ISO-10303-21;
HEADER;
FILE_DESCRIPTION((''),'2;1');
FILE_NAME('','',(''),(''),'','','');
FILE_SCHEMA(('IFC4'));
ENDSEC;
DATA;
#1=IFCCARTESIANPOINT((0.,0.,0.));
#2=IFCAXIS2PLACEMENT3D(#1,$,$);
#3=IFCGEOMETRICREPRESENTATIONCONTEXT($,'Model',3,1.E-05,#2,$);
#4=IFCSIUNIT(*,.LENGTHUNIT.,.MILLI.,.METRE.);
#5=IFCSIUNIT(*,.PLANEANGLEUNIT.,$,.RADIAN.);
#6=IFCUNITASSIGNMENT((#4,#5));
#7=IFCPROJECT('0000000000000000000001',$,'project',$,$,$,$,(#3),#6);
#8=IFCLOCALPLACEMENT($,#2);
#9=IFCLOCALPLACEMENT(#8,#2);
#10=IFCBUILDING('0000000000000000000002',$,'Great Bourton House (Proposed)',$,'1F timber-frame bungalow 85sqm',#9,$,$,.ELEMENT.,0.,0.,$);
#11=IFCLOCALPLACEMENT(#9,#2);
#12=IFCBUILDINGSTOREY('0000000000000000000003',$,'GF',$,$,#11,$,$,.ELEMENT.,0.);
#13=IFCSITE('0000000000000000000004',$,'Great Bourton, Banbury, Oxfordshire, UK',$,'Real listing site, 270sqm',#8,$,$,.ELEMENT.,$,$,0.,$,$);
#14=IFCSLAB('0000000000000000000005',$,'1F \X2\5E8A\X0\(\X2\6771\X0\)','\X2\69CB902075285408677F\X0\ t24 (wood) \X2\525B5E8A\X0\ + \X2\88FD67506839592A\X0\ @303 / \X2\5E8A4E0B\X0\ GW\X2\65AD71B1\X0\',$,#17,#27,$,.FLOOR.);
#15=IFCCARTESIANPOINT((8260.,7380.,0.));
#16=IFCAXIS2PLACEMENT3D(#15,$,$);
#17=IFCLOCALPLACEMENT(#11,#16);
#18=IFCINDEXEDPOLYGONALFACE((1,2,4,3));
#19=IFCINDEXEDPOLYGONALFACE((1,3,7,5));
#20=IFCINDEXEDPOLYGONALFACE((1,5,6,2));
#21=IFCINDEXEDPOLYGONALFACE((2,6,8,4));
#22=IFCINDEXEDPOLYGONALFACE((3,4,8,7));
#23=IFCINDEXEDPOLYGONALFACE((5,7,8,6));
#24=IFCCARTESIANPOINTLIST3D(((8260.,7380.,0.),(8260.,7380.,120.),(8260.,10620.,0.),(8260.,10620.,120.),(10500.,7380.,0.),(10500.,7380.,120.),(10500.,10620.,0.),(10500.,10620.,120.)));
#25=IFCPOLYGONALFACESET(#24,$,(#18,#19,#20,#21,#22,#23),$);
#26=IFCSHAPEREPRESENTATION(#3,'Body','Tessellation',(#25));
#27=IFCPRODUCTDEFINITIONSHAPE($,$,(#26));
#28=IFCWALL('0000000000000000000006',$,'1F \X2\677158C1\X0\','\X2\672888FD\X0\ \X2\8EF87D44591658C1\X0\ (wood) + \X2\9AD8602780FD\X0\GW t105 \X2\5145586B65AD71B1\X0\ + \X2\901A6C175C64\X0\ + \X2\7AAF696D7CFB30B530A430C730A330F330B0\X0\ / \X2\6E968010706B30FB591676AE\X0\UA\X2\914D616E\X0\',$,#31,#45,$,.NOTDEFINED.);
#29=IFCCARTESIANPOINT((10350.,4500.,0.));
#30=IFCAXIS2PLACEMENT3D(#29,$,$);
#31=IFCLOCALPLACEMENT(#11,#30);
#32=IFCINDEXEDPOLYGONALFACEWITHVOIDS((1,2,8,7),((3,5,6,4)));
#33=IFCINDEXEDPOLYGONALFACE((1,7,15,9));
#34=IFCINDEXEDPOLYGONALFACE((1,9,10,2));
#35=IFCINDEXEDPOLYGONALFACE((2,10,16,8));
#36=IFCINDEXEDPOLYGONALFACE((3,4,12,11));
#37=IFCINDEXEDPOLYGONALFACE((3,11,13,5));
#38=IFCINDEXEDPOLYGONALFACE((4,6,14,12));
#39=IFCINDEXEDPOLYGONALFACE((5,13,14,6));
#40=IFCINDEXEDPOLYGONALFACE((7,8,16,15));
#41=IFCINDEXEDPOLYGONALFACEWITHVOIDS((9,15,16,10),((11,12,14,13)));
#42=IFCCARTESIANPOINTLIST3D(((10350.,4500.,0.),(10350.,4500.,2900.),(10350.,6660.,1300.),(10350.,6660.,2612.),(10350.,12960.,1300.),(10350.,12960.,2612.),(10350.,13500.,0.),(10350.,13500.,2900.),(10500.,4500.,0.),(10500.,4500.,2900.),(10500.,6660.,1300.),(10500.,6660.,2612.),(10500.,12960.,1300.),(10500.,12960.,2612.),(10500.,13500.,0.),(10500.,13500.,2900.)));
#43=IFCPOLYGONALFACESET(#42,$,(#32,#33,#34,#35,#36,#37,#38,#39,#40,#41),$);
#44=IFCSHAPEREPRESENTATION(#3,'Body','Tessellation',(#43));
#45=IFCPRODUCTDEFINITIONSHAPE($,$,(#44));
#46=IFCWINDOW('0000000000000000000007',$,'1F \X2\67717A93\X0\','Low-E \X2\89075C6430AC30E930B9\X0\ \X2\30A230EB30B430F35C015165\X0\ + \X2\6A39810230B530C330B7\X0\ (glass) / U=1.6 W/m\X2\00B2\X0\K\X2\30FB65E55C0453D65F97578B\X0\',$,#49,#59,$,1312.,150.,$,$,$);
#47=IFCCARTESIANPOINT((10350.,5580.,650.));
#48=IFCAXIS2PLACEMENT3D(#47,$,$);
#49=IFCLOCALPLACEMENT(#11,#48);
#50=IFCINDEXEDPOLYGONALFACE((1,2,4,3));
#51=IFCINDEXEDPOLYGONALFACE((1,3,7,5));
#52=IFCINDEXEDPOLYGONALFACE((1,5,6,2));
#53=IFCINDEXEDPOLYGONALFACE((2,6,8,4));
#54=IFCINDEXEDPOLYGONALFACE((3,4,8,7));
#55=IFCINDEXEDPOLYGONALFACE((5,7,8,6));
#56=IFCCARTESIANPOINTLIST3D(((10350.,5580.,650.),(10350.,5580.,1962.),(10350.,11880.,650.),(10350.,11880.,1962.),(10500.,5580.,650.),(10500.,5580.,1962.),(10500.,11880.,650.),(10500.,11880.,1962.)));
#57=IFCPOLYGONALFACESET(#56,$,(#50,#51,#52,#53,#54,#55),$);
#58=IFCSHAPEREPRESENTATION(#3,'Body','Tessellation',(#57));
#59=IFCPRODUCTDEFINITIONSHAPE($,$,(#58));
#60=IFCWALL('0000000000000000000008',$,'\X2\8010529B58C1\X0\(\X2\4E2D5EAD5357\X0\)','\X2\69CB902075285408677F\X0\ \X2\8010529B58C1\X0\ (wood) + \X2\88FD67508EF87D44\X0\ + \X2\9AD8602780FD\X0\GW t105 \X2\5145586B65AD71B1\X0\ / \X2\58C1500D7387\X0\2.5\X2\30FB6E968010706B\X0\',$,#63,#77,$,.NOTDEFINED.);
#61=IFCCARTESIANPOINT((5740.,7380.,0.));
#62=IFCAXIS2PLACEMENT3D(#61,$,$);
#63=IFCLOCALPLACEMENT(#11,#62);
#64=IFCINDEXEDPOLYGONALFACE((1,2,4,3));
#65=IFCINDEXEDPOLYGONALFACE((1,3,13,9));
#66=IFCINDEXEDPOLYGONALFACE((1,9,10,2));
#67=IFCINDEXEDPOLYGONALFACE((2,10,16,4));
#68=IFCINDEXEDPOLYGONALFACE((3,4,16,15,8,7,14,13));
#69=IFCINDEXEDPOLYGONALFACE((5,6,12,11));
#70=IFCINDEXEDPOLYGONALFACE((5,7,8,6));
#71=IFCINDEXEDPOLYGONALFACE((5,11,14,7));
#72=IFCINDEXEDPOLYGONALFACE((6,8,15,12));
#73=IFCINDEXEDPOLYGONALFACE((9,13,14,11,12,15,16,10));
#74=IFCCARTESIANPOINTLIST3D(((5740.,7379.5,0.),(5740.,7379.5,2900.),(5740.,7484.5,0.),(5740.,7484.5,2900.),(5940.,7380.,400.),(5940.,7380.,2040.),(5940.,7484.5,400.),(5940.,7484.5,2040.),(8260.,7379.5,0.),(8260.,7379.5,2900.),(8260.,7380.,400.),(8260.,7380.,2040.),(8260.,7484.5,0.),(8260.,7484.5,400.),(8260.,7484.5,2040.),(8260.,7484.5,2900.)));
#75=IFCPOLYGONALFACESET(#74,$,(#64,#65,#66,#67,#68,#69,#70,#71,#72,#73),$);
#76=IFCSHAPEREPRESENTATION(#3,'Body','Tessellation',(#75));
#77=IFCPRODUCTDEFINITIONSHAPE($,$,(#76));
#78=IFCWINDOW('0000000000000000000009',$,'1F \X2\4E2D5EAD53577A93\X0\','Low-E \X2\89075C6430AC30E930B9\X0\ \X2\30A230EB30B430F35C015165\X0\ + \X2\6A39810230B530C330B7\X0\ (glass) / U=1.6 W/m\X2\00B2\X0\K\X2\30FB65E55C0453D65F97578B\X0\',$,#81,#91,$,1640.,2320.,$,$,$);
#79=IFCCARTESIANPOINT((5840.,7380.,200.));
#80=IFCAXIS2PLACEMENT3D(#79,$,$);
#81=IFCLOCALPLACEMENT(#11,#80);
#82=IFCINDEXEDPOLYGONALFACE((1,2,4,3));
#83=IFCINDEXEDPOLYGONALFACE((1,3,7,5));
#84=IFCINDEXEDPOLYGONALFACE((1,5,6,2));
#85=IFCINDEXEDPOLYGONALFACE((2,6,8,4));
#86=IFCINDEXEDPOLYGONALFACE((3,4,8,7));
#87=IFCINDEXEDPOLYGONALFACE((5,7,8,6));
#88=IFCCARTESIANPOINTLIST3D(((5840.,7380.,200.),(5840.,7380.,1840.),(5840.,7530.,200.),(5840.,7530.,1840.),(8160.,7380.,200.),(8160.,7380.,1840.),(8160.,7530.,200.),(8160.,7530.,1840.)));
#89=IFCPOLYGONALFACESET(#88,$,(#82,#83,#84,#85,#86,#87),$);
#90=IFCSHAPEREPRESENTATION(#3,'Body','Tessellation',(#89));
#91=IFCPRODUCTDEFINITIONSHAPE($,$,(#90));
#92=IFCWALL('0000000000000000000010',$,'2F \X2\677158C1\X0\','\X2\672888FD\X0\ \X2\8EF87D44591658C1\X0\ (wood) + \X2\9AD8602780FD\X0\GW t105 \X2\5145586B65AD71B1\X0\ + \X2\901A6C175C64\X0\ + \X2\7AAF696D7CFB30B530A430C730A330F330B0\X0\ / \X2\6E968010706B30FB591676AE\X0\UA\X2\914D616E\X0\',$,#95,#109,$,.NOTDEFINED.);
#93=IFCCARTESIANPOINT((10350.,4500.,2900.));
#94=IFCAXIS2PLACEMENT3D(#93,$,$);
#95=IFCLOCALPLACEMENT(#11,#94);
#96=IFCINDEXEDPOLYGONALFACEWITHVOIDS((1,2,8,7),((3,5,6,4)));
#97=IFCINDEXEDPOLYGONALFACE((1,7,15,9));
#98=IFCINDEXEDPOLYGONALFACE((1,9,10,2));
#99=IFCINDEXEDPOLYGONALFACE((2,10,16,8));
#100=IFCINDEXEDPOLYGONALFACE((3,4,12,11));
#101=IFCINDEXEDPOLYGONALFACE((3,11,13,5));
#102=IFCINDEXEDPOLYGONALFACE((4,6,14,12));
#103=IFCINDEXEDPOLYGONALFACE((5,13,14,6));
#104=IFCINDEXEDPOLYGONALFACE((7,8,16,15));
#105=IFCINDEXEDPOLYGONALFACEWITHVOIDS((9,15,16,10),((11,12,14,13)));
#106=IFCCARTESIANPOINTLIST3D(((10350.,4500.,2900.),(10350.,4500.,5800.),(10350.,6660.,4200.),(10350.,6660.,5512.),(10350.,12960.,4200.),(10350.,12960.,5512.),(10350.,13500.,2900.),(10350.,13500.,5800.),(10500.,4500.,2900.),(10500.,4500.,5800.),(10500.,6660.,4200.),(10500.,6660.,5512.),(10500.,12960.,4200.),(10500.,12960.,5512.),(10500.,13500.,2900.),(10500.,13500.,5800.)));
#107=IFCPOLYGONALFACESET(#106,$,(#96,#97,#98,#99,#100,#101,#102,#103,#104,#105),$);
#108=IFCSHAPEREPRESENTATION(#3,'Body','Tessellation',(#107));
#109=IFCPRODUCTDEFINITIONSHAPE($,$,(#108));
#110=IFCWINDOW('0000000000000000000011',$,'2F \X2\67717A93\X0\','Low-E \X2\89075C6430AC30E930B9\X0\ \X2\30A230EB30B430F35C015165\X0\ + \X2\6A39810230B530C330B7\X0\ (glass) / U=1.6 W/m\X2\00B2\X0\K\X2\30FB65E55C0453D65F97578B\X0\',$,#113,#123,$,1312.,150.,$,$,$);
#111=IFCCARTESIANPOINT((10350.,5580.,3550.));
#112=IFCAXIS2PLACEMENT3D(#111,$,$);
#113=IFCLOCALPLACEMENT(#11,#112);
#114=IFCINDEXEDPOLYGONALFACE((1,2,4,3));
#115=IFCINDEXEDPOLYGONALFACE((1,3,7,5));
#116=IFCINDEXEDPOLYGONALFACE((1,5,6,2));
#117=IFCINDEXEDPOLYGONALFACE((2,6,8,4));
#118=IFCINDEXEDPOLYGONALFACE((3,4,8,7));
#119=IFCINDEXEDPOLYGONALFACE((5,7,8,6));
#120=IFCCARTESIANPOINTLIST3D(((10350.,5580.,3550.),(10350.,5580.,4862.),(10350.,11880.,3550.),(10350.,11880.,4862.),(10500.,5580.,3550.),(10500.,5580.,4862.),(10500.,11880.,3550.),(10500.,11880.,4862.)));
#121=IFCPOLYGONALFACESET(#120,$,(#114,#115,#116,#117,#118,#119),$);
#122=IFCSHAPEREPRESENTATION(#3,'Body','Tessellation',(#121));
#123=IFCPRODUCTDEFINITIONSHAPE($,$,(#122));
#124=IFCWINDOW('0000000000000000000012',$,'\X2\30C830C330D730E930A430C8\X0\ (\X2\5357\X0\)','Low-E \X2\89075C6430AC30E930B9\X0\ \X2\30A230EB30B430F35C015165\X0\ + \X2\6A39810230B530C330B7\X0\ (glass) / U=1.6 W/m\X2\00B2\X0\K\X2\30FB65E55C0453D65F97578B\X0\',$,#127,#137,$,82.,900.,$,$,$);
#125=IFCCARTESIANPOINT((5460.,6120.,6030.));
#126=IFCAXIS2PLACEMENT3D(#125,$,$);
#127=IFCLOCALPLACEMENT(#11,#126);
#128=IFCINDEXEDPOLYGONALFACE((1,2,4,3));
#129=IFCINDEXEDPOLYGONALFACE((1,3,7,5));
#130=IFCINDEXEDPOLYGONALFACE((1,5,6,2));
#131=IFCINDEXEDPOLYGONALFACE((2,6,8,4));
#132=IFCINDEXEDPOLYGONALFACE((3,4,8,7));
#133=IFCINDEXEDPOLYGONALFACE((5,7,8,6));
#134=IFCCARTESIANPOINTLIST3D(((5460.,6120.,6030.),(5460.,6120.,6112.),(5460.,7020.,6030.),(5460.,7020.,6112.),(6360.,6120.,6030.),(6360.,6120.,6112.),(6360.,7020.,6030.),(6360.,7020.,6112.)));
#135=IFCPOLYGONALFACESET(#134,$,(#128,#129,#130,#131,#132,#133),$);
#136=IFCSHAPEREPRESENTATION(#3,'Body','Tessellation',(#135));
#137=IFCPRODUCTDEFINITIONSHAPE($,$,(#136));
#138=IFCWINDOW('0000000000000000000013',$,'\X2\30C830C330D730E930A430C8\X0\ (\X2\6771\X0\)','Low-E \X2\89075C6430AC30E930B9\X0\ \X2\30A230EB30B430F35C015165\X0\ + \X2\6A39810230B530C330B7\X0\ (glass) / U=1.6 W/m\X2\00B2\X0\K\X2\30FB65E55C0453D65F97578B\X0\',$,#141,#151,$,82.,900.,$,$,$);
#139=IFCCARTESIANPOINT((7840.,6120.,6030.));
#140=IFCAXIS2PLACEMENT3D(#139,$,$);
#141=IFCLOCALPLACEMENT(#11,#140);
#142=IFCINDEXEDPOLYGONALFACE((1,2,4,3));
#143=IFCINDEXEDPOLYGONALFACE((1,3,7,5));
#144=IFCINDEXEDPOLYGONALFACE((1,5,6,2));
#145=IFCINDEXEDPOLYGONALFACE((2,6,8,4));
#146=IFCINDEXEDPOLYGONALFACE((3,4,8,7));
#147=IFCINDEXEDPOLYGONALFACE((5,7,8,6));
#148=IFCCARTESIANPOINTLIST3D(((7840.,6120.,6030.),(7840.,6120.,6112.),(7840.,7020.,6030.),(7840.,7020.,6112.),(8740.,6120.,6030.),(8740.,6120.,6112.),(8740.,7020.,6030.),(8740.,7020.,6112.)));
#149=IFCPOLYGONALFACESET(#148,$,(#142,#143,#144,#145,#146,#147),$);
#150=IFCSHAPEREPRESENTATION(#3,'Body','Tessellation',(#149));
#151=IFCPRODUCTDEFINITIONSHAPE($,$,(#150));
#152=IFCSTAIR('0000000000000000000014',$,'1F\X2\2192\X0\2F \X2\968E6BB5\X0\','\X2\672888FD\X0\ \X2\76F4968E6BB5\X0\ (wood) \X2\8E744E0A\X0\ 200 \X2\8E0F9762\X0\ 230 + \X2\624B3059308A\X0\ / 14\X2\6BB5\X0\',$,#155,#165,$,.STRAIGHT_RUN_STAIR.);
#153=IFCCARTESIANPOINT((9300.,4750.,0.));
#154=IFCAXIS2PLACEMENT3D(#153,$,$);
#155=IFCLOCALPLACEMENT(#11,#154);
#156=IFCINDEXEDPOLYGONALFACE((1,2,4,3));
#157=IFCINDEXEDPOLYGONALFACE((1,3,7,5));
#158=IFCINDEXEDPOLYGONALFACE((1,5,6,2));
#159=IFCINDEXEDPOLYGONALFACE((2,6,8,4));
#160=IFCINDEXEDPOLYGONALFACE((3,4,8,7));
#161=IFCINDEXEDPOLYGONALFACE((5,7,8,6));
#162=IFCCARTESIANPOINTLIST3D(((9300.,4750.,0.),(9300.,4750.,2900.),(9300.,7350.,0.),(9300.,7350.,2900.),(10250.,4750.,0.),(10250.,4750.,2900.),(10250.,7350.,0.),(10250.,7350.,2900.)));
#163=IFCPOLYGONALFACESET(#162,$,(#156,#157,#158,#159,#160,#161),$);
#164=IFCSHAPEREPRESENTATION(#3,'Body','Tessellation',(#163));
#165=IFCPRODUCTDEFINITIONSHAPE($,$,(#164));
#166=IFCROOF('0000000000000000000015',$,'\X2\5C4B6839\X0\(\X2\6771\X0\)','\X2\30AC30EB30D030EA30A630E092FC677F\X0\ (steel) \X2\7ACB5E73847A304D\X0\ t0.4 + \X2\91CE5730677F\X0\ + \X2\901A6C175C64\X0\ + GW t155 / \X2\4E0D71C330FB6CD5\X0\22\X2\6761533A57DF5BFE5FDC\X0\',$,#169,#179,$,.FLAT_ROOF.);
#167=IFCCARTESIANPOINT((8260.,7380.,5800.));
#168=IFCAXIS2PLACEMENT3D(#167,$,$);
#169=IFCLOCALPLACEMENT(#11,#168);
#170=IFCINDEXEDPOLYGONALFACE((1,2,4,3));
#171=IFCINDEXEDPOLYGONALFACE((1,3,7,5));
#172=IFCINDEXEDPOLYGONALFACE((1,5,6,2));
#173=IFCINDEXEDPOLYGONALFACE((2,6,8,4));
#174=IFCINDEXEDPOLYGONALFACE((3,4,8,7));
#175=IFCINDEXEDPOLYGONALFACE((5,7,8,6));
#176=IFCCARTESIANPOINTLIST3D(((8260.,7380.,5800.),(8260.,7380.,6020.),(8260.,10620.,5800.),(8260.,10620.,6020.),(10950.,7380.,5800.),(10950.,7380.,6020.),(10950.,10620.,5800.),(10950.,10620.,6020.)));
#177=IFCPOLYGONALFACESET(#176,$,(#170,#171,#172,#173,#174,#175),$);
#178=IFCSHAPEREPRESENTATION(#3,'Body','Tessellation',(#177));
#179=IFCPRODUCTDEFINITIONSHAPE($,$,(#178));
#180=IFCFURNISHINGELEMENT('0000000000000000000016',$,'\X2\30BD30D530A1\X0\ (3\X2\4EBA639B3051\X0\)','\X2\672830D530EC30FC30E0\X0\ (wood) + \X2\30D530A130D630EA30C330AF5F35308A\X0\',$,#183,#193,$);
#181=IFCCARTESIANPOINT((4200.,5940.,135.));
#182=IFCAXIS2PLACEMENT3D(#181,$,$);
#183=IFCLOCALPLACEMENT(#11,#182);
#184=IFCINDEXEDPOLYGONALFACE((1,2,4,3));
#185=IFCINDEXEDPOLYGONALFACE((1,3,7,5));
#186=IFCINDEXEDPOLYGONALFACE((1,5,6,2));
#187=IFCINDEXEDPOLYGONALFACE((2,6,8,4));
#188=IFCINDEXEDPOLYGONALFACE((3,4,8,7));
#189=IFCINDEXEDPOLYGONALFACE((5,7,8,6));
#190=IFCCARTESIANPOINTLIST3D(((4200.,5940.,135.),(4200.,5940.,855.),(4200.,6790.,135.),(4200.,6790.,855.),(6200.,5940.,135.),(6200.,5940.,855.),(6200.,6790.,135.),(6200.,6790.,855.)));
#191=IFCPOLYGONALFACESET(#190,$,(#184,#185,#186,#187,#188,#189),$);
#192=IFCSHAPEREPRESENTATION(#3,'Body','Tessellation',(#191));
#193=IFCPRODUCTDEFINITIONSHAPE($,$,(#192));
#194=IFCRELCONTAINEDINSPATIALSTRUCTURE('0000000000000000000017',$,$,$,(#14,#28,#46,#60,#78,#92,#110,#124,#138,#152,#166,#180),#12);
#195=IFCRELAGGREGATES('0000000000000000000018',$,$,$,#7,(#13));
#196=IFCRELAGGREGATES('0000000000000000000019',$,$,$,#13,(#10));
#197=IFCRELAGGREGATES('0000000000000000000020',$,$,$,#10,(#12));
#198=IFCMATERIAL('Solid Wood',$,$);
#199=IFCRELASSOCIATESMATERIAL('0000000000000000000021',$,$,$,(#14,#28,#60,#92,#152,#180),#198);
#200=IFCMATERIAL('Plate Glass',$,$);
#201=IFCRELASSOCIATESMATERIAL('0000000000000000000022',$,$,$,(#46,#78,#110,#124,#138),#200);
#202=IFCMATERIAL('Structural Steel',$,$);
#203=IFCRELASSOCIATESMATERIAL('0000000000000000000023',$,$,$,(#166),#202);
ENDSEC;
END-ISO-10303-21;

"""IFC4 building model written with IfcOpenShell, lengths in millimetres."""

from ifc_helpers import new_model, si_unit, frame, frame_2d, origin, place, context, project, spatial, rectangle, extrude, material, element, fill, save


model = new_model("IFC4")

# Units and contexts
model_context = context("Model", 3, precision=1e-05, world=origin())
ifc_project = project(units=[si_unit("LENGTHUNIT", "METRE", prefix="MILLI"), si_unit("PLANEANGLEUNIT", "RADIAN")], contexts=[model_context])

# Site, building, storey
site_placement = place(None, origin())
site = spatial("IfcSite", under=ifc_project, at=site_placement, Name="Great Bourton, Banbury, Oxfordshire, UK", ObjectType="Real listing site, 270sqm", CompositionType="ELEMENT", RefElevation=0.0)
building_placement = place(site_placement, origin())
building = spatial("IfcBuilding", under=site, at=building_placement, Name="Great Bourton House (Proposed)", ObjectType="1F timber-frame bungalow 85sqm", CompositionType="ELEMENT", ElevationOfRefHeight=0.0, ElevationOfTerrain=0.0)
storey_placement = place(building_placement, origin())
storey = spatial("IfcBuildingStorey", under=building, at=storey_placement, Name="GF", CompositionType="ELEMENT", Elevation=0.0)

# Slab
ifc_material_1 = material(Name="Solid Wood")
slab_placement = place(storey_placement, frame((8260.0, 7380.0, 0.0)))
element("IfcSlab", 1, at=slab_placement, inside=storey, material=ifc_material_1, Name="1F 床(東)", Description="構造用合板 t24 (wood) 剛床 + 製材根太 @303 / 床下 GW断熱", PredefinedType="FLOOR", context=model_context, shape_type="SweptSolid", body=[
    extrude(rectangle(XDim=2240.0, YDim=3240.0, at=frame_2d((1120.0, 1620.0))), frame((8260.0, 7380.0, 0.0)), (0.0, 0.0, 1.0), 120.0),
])

# Walls, openings, windows
wall_1_placement = place(storey_placement, frame((10350.0, 4500.0, 0.0)))
wall_1 = element("IfcWall", 2, at=wall_1_placement, inside=storey, material=ifc_material_1, Name="1F 東壁", Description="木製 軸組外壁 (wood) + 高性能GW t105 充填断熱 + 通気層 + 窯業系サイディング / 準耐火・外皮UA配慮", PredefinedType="NOTDEFINED", context=model_context, shape_type="SweptSolid", body=[
    extrude(rectangle(XDim=150.0, YDim=9000.0, at=frame_2d((75.0, 4500.0))), frame((10350.0, 4500.0, 0.0)), (0.0, 0.0, 1.0), 2900.0),
])
opening_1_placement = place(storey_placement, frame((10350.0, 5580.0, 650.0)))
opening_1 = element("IfcOpeningElement", 3, at=opening_1_placement, cuts=wall_1, PredefinedType="NOTDEFINED", context=model_context, shape_type="SweptSolid", body=[
    extrude(rectangle(XDim=150.0, YDim=6300.0, at=frame_2d((75.0, 3150.0))), frame((10350.0, 5580.0, 650.0)), (0.0, 0.0, 1.0), 1312.0),
])
ifc_material_2 = material(Name="Plate Glass")
window_1_placement = place(storey_placement, frame((10350.0, 5580.0, 650.0)))
window_1 = element("IfcWindow", 4, at=window_1_placement, inside=storey, material=ifc_material_2, Name="1F 東窓", Description="Low-E 複層ガラス アルゴン封入 + 樹脂サッシ (glass) / U=1.6 W/m²K・日射取得型", OverallHeight=1312.0, OverallWidth=150.0, context=model_context, shape_type="SweptSolid", body=[
    extrude(rectangle(XDim=150.0, YDim=6300.0, at=frame_2d((75.0, 3150.0))), frame((10350.0, 5580.0, 650.0)), (0.0, 0.0, 1.0), 1312.0),
])
fill(opening_1, window_1)
wall_2_placement = place(storey_placement, frame((5740.0, 7380.0, 0.0)))
wall_2 = element("IfcWall", 5, at=wall_2_placement, inside=storey, material=ifc_material_1, Name="耐力壁(中庭南)", Description="構造用合板 耐力壁 (wood) + 製材軸組 + 高性能GW t105 充填断熱 / 壁倍率2.5・準耐火", PredefinedType="NOTDEFINED", context=model_context, shape_type="SweptSolid", body=[
    extrude(rectangle(XDim=2520.0, YDim=105.0, at=frame_2d((1260.0, 52.0))), frame((5740.0, 7380.0, 0.0)), (0.0, 0.0, 1.0), 2900.0),
])
opening_2_placement = place(storey_placement, frame((5840.0, 7380.0, 200.0)))
opening_2 = element("IfcOpeningElement", 6, at=opening_2_placement, cuts=wall_2, PredefinedType="NOTDEFINED", context=model_context, shape_type="SweptSolid", body=[
    extrude(rectangle(XDim=2320.0, YDim=150.0, at=frame_2d((1160.0, 75.0))), frame((5840.0, 7380.0, 200.0)), (0.0, 0.0, 1.0), 1640.0),
])
window_2_placement = place(storey_placement, frame((5840.0, 7380.0, 200.0)))
window_2 = element("IfcWindow", 7, at=window_2_placement, inside=storey, material=ifc_material_2, Name="1F 中庭南窓", Description="Low-E 複層ガラス アルゴン封入 + 樹脂サッシ (glass) / U=1.6 W/m²K・日射取得型", OverallHeight=1640.0, OverallWidth=2320.0, context=model_context, shape_type="SweptSolid", body=[
    extrude(rectangle(XDim=2320.0, YDim=150.0, at=frame_2d((1160.0, 75.0))), frame((5840.0, 7380.0, 200.0)), (0.0, 0.0, 1.0), 1640.0),
])
fill(opening_2, window_2)

# Wall, opening, window
wall_3_placement = place(storey_placement, frame((10350.0, 4500.0, 2900.0)))
wall_3 = element("IfcWall", 8, at=wall_3_placement, inside=storey, material=ifc_material_1, Name="2F 東壁", Description="木製 軸組外壁 (wood) + 高性能GW t105 充填断熱 + 通気層 + 窯業系サイディング / 準耐火・外皮UA配慮", PredefinedType="NOTDEFINED", context=model_context, shape_type="SweptSolid", body=[
    extrude(rectangle(XDim=150.0, YDim=9000.0, at=frame_2d((75.0, 4500.0))), frame((10350.0, 4500.0, 2900.0)), (0.0, 0.0, 1.0), 2900.0),
])
opening_3_placement = place(storey_placement, frame((10350.0, 5580.0, 3550.0)))
opening_3 = element("IfcOpeningElement", 9, at=opening_3_placement, cuts=wall_3, PredefinedType="NOTDEFINED", context=model_context, shape_type="SweptSolid", body=[
    extrude(rectangle(XDim=150.0, YDim=6300.0, at=frame_2d((75.0, 3150.0))), frame((10350.0, 5580.0, 3550.0)), (0.0, 0.0, 1.0), 1312.0),
])
window_3_placement = place(storey_placement, frame((10350.0, 5580.0, 3550.0)))
window_3 = element("IfcWindow", 10, at=window_3_placement, inside=storey, material=ifc_material_2, Name="2F 東窓", Description="Low-E 複層ガラス アルゴン封入 + 樹脂サッシ (glass) / U=1.6 W/m²K・日射取得型", OverallHeight=1312.0, OverallWidth=150.0, context=model_context, shape_type="SweptSolid", body=[
    extrude(rectangle(XDim=150.0, YDim=6300.0, at=frame_2d((75.0, 3150.0))), frame((10350.0, 5580.0, 3550.0)), (0.0, 0.0, 1.0), 1312.0),
])
fill(opening_3, window_3)

# Windows
window_4_placement = place(storey_placement, frame((5460.0, 6120.0, 6030.0)))
element("IfcWindow", 11, at=window_4_placement, inside=storey, material=ifc_material_2, Name="トップライト (南)", Description="Low-E 複層ガラス アルゴン封入 + 樹脂サッシ (glass) / U=1.6 W/m²K・日射取得型", OverallHeight=82.0, OverallWidth=900.0, context=model_context, shape_type="SweptSolid", body=[
    extrude(rectangle(XDim=900.0, YDim=900.0, at=frame_2d((450.0, 450.0))), frame((5460.0, 6120.0, 6030.0)), (0.0, 0.0, 1.0), 82.0),
])
window_5_placement = place(storey_placement, frame((7840.0, 6120.0, 6030.0)))
element("IfcWindow", 12, at=window_5_placement, inside=storey, material=ifc_material_2, Name="トップライト (東)", Description="Low-E 複層ガラス アルゴン封入 + 樹脂サッシ (glass) / U=1.6 W/m²K・日射取得型", OverallHeight=82.0, OverallWidth=900.0, context=model_context, shape_type="SweptSolid", body=[
    extrude(rectangle(XDim=900.0, YDim=900.0, at=frame_2d((450.0, 450.0))), frame((7840.0, 6120.0, 6030.0)), (0.0, 0.0, 1.0), 82.0),
])

# Stair
stair_placement = place(storey_placement, frame((9300.0, 4750.0, 0.0)))
element("IfcStair", 13, at=stair_placement, inside=storey, material=ifc_material_1, Name="1F→2F 階段", Description="木製 直階段 (wood) 蹴上 200 踏面 230 + 手すり / 14段", PredefinedType="STRAIGHT_RUN_STAIR", context=model_context, shape_type="SweptSolid", body=[
    extrude(rectangle(XDim=950.0, YDim=2600.0, at=frame_2d((475.0, 1300.0))), frame((9300.0, 4750.0, 0.0)), (0.0, 0.0, 1.0), 2900.0),
])

# Roof
ifc_material_3 = material(Name="Structural Steel")
roof_placement = place(storey_placement, frame((8260.0, 7380.0, 5800.0)))
element("IfcRoof", 14, at=roof_placement, inside=storey, material=ifc_material_3, Name="屋根(東)", Description="ガルバリウム鋼板 (steel) 立平葺き t0.4 + 野地板 + 通気層 + GW t155 / 不燃・法22条区域対応", PredefinedType="FLAT_ROOF", context=model_context, shape_type="SweptSolid", body=[
    extrude(rectangle(XDim=2690.0, YDim=3240.0, at=frame_2d((1345.0, 1620.0))), frame((8260.0, 7380.0, 5800.0)), (0.0, 0.0, 1.0), 220.0),
])

# Furnishing element
furnishing_1_placement = place(storey_placement, frame((4200.0, 5940.0, 135.0)))
element("IfcFurnishingElement", 15, at=furnishing_1_placement, inside=storey, material=ifc_material_1, Name="ソファ (3人掛け)", Description="木フレーム (wood) + ファブリック張り", context=model_context, shape_type="SweptSolid", body=[
    extrude(rectangle(XDim=2000.0, YDim=850.0, at=frame_2d((1000.0, 425.0))), frame((4200.0, 5940.0, 135.0)), (0.0, 0.0, 1.0), 720.0),
])

save(model, "model.ifc")
